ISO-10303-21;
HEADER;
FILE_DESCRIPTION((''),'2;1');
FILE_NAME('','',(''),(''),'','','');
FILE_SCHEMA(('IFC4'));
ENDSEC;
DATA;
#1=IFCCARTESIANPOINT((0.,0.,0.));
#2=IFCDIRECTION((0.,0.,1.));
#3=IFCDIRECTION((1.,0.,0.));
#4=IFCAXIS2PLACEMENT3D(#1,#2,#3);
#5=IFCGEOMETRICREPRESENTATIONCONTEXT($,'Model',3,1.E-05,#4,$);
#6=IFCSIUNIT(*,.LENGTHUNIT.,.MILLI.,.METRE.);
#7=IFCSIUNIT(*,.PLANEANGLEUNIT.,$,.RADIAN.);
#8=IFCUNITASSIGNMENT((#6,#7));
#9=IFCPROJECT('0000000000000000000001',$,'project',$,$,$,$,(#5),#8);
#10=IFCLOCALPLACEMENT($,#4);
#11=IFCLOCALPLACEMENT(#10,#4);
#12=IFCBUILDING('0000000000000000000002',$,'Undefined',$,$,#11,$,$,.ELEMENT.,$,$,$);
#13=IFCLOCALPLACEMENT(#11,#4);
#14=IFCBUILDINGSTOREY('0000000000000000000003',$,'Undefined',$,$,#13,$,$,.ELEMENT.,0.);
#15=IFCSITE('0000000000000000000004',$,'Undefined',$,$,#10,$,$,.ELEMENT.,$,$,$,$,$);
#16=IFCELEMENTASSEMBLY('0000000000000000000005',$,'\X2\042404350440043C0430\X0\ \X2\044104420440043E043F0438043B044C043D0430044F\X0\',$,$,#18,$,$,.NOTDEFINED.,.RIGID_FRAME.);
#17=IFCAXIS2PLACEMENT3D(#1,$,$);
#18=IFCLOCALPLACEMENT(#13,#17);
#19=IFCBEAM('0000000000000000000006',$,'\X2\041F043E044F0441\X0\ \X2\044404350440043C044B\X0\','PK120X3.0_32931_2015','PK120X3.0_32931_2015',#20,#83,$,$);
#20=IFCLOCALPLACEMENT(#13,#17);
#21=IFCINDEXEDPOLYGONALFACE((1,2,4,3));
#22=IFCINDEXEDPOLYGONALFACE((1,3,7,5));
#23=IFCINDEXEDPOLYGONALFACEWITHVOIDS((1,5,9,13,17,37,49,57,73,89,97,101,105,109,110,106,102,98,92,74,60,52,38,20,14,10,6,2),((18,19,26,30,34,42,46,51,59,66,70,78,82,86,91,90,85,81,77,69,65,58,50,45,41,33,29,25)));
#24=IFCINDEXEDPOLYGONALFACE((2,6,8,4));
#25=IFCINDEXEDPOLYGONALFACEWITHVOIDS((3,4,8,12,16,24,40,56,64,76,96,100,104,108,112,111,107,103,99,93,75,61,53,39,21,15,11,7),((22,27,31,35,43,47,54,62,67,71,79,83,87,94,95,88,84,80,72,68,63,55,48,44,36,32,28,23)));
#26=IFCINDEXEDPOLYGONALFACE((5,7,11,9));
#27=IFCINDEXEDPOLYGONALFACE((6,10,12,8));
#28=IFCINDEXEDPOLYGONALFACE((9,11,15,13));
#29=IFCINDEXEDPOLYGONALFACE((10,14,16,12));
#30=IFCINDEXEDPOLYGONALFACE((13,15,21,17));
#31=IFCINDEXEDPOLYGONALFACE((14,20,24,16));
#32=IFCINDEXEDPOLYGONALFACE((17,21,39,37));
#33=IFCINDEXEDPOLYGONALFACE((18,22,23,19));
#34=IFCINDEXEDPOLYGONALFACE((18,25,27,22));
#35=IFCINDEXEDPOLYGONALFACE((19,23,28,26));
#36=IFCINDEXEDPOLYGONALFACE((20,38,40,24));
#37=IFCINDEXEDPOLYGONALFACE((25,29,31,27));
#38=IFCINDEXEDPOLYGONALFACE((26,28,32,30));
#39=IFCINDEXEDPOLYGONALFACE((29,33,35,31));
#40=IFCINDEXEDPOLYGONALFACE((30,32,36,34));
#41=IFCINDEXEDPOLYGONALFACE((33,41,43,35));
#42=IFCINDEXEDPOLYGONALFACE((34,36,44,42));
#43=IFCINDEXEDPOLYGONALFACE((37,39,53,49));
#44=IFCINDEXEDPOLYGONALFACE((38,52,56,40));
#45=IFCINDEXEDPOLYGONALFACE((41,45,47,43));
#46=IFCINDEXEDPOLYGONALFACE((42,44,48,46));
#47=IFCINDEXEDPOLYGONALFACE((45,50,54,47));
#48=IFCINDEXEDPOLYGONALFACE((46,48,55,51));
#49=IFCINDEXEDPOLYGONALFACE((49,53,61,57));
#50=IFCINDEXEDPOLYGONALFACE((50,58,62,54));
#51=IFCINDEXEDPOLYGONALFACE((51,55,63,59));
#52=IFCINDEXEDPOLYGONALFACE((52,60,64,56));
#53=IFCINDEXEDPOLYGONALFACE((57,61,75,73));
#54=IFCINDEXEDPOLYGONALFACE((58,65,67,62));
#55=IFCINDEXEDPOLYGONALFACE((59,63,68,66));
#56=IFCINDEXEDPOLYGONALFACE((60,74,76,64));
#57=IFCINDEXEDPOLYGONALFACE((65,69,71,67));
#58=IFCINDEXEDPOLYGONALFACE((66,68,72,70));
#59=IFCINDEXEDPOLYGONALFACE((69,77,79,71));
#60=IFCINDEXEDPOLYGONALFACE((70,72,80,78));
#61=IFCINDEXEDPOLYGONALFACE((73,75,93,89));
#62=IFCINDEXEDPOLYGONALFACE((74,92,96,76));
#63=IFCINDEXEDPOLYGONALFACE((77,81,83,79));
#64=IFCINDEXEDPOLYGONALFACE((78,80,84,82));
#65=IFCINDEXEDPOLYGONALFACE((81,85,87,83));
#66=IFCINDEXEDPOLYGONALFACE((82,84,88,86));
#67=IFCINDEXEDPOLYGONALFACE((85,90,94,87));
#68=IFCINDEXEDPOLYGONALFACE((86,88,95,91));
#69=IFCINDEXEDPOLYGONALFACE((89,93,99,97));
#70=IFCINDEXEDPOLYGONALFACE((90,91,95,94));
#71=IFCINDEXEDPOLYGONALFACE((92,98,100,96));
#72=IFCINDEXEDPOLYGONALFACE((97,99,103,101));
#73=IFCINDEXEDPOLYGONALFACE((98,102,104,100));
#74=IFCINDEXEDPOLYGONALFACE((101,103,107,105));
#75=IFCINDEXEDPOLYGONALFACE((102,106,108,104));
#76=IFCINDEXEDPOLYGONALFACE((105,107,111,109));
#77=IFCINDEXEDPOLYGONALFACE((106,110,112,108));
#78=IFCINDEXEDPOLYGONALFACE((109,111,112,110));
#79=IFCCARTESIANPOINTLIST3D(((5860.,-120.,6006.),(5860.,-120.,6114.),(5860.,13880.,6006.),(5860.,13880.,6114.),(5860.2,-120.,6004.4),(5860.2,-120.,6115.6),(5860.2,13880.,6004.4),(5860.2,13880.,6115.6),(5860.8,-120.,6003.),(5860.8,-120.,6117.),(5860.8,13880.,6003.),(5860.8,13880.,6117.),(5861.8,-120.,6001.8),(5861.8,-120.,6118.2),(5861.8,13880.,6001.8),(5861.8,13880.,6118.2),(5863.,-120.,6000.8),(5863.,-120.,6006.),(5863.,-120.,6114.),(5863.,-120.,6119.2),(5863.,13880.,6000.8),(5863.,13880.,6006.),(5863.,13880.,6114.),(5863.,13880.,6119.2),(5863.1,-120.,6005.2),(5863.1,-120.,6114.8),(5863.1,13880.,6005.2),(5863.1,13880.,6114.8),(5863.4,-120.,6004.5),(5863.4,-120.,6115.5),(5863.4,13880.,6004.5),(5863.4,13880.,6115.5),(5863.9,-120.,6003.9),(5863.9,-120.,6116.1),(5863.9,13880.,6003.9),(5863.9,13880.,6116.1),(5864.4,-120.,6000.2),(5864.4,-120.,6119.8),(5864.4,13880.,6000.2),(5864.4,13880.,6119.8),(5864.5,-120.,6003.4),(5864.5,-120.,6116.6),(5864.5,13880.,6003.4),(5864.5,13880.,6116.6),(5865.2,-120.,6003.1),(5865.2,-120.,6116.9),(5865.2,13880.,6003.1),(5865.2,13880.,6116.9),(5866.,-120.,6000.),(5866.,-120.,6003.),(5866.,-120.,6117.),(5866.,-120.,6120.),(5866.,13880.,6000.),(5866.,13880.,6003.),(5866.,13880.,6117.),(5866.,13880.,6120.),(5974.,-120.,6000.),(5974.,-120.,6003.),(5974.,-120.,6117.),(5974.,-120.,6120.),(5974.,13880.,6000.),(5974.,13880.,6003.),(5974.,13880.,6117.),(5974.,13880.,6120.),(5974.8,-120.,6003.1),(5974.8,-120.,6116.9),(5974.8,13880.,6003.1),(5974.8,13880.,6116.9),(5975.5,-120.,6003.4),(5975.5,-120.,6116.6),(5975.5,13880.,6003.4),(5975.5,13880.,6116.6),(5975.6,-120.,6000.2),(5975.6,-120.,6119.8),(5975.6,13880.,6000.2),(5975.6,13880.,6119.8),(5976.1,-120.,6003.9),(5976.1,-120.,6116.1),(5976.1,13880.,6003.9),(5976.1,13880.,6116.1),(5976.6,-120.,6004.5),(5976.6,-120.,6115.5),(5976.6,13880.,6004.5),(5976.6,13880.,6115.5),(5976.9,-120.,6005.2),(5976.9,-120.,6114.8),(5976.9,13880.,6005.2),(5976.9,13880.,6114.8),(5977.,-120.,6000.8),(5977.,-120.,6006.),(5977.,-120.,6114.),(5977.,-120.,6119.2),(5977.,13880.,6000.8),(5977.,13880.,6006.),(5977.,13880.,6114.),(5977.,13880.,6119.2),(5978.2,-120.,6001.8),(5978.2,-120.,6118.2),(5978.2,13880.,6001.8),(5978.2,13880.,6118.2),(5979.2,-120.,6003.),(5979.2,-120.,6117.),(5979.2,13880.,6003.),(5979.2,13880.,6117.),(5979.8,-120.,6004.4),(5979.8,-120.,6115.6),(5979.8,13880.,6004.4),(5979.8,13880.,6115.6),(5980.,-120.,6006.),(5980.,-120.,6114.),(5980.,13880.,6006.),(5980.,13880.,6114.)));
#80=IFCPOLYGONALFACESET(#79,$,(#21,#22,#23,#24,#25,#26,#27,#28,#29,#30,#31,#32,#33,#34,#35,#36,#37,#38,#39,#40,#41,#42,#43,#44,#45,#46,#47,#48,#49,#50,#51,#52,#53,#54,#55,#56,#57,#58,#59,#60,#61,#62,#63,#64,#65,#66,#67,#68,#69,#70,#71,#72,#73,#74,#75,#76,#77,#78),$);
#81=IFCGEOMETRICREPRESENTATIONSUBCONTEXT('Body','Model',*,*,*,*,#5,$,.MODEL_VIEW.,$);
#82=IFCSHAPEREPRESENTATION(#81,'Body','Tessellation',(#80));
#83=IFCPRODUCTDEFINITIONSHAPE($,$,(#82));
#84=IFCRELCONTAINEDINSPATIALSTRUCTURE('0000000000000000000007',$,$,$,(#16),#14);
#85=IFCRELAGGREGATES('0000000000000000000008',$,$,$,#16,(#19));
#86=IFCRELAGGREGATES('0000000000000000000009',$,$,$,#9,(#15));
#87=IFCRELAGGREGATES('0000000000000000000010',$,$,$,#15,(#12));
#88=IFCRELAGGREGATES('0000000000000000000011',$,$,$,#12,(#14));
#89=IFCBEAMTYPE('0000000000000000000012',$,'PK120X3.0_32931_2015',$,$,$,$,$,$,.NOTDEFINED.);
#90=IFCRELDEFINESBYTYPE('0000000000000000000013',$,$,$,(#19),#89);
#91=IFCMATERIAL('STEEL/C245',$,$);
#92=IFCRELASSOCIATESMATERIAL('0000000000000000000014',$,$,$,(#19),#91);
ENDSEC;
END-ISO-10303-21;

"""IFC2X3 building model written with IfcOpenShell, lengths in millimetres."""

from ifc_helpers import new_model, si_unit, frame, origin_with_axes, origin_2d_with_axis, place, context, subcontext, project, spatial, hollow_rectangle, extrude, material, type_object, element, aggregate, save


model = new_model("IFC2X3")

# Units and contexts
model_context = context("Model", 3, precision=1e-05, world=origin_with_axes())
body_context = subcontext(model_context, "Body", "Model", "MODEL_VIEW")
ifc_project = project(units=[si_unit("LENGTHUNIT", "METRE", prefix="MILLI"), si_unit("PLANEANGLEUNIT", "RADIAN")], contexts=[model_context])

# Site, building, storey
site_placement = place(None, origin_with_axes())
site = spatial("IfcSite", under=ifc_project, at=site_placement, Name="Undefined", CompositionType="ELEMENT")
building_placement = place(site_placement, origin_with_axes())
building = spatial("IfcBuilding", under=site, at=building_placement, Name="Undefined", CompositionType="ELEMENT")
storey_placement = place(building_placement, origin_with_axes())
storey = spatial("IfcBuildingStorey", under=building, at=storey_placement, Name="Undefined", CompositionType="ELEMENT", Elevation=0.0)

# Shared definitions
ifc_material = material(Name="STEEL/C245")

# Element assembly
assembly_1_placement = place(storey_placement, origin_with_axes())
assembly_1 = element("IfcElementAssembly", 1, at=assembly_1_placement, inside=storey, Name="Ферма стропильная", AssemblyPlace="NOTDEFINED", PredefinedType="RIGID_FRAME")

# Beam
beam_type_1 = type_object("IfcBeamType", Name="PK120X3.0_32931_2015", PredefinedType="NOTDEFINED")
beam_1_placement = place(assembly_1_placement, frame((5920.0, -120.0, 6060.0), z_axis=(0.0, 0.0, 1.0), x_axis=(0.0, 1.0, 0.0)))
beam_1 = element("IfcBeam", 2, at=beam_1_placement, type_object=beam_type_1, material=ifc_material, Name="Пояс фермы", Description="PK120X3.0_32931_2015", ObjectType="PK120X3.0_32931_2015", context=body_context, shape_type="SweptSolid", body=[
    extrude(hollow_rectangle(XDim=120.0, YDim=120.0, WallThickness=3.0, InnerFilletRadius=3.0, OuterFilletRadius=6.0, at=origin_2d_with_axis()), frame((14000.0, 0.0, 0.0), z_axis=(-1.0, 0.0, 0.0), x_axis=(0.0, -1.0, 0.0)), (0.0, 0.0, 1.0), 14000.0),
])
aggregate(assembly_1, [beam_1])

save(model, "model.ifc")
